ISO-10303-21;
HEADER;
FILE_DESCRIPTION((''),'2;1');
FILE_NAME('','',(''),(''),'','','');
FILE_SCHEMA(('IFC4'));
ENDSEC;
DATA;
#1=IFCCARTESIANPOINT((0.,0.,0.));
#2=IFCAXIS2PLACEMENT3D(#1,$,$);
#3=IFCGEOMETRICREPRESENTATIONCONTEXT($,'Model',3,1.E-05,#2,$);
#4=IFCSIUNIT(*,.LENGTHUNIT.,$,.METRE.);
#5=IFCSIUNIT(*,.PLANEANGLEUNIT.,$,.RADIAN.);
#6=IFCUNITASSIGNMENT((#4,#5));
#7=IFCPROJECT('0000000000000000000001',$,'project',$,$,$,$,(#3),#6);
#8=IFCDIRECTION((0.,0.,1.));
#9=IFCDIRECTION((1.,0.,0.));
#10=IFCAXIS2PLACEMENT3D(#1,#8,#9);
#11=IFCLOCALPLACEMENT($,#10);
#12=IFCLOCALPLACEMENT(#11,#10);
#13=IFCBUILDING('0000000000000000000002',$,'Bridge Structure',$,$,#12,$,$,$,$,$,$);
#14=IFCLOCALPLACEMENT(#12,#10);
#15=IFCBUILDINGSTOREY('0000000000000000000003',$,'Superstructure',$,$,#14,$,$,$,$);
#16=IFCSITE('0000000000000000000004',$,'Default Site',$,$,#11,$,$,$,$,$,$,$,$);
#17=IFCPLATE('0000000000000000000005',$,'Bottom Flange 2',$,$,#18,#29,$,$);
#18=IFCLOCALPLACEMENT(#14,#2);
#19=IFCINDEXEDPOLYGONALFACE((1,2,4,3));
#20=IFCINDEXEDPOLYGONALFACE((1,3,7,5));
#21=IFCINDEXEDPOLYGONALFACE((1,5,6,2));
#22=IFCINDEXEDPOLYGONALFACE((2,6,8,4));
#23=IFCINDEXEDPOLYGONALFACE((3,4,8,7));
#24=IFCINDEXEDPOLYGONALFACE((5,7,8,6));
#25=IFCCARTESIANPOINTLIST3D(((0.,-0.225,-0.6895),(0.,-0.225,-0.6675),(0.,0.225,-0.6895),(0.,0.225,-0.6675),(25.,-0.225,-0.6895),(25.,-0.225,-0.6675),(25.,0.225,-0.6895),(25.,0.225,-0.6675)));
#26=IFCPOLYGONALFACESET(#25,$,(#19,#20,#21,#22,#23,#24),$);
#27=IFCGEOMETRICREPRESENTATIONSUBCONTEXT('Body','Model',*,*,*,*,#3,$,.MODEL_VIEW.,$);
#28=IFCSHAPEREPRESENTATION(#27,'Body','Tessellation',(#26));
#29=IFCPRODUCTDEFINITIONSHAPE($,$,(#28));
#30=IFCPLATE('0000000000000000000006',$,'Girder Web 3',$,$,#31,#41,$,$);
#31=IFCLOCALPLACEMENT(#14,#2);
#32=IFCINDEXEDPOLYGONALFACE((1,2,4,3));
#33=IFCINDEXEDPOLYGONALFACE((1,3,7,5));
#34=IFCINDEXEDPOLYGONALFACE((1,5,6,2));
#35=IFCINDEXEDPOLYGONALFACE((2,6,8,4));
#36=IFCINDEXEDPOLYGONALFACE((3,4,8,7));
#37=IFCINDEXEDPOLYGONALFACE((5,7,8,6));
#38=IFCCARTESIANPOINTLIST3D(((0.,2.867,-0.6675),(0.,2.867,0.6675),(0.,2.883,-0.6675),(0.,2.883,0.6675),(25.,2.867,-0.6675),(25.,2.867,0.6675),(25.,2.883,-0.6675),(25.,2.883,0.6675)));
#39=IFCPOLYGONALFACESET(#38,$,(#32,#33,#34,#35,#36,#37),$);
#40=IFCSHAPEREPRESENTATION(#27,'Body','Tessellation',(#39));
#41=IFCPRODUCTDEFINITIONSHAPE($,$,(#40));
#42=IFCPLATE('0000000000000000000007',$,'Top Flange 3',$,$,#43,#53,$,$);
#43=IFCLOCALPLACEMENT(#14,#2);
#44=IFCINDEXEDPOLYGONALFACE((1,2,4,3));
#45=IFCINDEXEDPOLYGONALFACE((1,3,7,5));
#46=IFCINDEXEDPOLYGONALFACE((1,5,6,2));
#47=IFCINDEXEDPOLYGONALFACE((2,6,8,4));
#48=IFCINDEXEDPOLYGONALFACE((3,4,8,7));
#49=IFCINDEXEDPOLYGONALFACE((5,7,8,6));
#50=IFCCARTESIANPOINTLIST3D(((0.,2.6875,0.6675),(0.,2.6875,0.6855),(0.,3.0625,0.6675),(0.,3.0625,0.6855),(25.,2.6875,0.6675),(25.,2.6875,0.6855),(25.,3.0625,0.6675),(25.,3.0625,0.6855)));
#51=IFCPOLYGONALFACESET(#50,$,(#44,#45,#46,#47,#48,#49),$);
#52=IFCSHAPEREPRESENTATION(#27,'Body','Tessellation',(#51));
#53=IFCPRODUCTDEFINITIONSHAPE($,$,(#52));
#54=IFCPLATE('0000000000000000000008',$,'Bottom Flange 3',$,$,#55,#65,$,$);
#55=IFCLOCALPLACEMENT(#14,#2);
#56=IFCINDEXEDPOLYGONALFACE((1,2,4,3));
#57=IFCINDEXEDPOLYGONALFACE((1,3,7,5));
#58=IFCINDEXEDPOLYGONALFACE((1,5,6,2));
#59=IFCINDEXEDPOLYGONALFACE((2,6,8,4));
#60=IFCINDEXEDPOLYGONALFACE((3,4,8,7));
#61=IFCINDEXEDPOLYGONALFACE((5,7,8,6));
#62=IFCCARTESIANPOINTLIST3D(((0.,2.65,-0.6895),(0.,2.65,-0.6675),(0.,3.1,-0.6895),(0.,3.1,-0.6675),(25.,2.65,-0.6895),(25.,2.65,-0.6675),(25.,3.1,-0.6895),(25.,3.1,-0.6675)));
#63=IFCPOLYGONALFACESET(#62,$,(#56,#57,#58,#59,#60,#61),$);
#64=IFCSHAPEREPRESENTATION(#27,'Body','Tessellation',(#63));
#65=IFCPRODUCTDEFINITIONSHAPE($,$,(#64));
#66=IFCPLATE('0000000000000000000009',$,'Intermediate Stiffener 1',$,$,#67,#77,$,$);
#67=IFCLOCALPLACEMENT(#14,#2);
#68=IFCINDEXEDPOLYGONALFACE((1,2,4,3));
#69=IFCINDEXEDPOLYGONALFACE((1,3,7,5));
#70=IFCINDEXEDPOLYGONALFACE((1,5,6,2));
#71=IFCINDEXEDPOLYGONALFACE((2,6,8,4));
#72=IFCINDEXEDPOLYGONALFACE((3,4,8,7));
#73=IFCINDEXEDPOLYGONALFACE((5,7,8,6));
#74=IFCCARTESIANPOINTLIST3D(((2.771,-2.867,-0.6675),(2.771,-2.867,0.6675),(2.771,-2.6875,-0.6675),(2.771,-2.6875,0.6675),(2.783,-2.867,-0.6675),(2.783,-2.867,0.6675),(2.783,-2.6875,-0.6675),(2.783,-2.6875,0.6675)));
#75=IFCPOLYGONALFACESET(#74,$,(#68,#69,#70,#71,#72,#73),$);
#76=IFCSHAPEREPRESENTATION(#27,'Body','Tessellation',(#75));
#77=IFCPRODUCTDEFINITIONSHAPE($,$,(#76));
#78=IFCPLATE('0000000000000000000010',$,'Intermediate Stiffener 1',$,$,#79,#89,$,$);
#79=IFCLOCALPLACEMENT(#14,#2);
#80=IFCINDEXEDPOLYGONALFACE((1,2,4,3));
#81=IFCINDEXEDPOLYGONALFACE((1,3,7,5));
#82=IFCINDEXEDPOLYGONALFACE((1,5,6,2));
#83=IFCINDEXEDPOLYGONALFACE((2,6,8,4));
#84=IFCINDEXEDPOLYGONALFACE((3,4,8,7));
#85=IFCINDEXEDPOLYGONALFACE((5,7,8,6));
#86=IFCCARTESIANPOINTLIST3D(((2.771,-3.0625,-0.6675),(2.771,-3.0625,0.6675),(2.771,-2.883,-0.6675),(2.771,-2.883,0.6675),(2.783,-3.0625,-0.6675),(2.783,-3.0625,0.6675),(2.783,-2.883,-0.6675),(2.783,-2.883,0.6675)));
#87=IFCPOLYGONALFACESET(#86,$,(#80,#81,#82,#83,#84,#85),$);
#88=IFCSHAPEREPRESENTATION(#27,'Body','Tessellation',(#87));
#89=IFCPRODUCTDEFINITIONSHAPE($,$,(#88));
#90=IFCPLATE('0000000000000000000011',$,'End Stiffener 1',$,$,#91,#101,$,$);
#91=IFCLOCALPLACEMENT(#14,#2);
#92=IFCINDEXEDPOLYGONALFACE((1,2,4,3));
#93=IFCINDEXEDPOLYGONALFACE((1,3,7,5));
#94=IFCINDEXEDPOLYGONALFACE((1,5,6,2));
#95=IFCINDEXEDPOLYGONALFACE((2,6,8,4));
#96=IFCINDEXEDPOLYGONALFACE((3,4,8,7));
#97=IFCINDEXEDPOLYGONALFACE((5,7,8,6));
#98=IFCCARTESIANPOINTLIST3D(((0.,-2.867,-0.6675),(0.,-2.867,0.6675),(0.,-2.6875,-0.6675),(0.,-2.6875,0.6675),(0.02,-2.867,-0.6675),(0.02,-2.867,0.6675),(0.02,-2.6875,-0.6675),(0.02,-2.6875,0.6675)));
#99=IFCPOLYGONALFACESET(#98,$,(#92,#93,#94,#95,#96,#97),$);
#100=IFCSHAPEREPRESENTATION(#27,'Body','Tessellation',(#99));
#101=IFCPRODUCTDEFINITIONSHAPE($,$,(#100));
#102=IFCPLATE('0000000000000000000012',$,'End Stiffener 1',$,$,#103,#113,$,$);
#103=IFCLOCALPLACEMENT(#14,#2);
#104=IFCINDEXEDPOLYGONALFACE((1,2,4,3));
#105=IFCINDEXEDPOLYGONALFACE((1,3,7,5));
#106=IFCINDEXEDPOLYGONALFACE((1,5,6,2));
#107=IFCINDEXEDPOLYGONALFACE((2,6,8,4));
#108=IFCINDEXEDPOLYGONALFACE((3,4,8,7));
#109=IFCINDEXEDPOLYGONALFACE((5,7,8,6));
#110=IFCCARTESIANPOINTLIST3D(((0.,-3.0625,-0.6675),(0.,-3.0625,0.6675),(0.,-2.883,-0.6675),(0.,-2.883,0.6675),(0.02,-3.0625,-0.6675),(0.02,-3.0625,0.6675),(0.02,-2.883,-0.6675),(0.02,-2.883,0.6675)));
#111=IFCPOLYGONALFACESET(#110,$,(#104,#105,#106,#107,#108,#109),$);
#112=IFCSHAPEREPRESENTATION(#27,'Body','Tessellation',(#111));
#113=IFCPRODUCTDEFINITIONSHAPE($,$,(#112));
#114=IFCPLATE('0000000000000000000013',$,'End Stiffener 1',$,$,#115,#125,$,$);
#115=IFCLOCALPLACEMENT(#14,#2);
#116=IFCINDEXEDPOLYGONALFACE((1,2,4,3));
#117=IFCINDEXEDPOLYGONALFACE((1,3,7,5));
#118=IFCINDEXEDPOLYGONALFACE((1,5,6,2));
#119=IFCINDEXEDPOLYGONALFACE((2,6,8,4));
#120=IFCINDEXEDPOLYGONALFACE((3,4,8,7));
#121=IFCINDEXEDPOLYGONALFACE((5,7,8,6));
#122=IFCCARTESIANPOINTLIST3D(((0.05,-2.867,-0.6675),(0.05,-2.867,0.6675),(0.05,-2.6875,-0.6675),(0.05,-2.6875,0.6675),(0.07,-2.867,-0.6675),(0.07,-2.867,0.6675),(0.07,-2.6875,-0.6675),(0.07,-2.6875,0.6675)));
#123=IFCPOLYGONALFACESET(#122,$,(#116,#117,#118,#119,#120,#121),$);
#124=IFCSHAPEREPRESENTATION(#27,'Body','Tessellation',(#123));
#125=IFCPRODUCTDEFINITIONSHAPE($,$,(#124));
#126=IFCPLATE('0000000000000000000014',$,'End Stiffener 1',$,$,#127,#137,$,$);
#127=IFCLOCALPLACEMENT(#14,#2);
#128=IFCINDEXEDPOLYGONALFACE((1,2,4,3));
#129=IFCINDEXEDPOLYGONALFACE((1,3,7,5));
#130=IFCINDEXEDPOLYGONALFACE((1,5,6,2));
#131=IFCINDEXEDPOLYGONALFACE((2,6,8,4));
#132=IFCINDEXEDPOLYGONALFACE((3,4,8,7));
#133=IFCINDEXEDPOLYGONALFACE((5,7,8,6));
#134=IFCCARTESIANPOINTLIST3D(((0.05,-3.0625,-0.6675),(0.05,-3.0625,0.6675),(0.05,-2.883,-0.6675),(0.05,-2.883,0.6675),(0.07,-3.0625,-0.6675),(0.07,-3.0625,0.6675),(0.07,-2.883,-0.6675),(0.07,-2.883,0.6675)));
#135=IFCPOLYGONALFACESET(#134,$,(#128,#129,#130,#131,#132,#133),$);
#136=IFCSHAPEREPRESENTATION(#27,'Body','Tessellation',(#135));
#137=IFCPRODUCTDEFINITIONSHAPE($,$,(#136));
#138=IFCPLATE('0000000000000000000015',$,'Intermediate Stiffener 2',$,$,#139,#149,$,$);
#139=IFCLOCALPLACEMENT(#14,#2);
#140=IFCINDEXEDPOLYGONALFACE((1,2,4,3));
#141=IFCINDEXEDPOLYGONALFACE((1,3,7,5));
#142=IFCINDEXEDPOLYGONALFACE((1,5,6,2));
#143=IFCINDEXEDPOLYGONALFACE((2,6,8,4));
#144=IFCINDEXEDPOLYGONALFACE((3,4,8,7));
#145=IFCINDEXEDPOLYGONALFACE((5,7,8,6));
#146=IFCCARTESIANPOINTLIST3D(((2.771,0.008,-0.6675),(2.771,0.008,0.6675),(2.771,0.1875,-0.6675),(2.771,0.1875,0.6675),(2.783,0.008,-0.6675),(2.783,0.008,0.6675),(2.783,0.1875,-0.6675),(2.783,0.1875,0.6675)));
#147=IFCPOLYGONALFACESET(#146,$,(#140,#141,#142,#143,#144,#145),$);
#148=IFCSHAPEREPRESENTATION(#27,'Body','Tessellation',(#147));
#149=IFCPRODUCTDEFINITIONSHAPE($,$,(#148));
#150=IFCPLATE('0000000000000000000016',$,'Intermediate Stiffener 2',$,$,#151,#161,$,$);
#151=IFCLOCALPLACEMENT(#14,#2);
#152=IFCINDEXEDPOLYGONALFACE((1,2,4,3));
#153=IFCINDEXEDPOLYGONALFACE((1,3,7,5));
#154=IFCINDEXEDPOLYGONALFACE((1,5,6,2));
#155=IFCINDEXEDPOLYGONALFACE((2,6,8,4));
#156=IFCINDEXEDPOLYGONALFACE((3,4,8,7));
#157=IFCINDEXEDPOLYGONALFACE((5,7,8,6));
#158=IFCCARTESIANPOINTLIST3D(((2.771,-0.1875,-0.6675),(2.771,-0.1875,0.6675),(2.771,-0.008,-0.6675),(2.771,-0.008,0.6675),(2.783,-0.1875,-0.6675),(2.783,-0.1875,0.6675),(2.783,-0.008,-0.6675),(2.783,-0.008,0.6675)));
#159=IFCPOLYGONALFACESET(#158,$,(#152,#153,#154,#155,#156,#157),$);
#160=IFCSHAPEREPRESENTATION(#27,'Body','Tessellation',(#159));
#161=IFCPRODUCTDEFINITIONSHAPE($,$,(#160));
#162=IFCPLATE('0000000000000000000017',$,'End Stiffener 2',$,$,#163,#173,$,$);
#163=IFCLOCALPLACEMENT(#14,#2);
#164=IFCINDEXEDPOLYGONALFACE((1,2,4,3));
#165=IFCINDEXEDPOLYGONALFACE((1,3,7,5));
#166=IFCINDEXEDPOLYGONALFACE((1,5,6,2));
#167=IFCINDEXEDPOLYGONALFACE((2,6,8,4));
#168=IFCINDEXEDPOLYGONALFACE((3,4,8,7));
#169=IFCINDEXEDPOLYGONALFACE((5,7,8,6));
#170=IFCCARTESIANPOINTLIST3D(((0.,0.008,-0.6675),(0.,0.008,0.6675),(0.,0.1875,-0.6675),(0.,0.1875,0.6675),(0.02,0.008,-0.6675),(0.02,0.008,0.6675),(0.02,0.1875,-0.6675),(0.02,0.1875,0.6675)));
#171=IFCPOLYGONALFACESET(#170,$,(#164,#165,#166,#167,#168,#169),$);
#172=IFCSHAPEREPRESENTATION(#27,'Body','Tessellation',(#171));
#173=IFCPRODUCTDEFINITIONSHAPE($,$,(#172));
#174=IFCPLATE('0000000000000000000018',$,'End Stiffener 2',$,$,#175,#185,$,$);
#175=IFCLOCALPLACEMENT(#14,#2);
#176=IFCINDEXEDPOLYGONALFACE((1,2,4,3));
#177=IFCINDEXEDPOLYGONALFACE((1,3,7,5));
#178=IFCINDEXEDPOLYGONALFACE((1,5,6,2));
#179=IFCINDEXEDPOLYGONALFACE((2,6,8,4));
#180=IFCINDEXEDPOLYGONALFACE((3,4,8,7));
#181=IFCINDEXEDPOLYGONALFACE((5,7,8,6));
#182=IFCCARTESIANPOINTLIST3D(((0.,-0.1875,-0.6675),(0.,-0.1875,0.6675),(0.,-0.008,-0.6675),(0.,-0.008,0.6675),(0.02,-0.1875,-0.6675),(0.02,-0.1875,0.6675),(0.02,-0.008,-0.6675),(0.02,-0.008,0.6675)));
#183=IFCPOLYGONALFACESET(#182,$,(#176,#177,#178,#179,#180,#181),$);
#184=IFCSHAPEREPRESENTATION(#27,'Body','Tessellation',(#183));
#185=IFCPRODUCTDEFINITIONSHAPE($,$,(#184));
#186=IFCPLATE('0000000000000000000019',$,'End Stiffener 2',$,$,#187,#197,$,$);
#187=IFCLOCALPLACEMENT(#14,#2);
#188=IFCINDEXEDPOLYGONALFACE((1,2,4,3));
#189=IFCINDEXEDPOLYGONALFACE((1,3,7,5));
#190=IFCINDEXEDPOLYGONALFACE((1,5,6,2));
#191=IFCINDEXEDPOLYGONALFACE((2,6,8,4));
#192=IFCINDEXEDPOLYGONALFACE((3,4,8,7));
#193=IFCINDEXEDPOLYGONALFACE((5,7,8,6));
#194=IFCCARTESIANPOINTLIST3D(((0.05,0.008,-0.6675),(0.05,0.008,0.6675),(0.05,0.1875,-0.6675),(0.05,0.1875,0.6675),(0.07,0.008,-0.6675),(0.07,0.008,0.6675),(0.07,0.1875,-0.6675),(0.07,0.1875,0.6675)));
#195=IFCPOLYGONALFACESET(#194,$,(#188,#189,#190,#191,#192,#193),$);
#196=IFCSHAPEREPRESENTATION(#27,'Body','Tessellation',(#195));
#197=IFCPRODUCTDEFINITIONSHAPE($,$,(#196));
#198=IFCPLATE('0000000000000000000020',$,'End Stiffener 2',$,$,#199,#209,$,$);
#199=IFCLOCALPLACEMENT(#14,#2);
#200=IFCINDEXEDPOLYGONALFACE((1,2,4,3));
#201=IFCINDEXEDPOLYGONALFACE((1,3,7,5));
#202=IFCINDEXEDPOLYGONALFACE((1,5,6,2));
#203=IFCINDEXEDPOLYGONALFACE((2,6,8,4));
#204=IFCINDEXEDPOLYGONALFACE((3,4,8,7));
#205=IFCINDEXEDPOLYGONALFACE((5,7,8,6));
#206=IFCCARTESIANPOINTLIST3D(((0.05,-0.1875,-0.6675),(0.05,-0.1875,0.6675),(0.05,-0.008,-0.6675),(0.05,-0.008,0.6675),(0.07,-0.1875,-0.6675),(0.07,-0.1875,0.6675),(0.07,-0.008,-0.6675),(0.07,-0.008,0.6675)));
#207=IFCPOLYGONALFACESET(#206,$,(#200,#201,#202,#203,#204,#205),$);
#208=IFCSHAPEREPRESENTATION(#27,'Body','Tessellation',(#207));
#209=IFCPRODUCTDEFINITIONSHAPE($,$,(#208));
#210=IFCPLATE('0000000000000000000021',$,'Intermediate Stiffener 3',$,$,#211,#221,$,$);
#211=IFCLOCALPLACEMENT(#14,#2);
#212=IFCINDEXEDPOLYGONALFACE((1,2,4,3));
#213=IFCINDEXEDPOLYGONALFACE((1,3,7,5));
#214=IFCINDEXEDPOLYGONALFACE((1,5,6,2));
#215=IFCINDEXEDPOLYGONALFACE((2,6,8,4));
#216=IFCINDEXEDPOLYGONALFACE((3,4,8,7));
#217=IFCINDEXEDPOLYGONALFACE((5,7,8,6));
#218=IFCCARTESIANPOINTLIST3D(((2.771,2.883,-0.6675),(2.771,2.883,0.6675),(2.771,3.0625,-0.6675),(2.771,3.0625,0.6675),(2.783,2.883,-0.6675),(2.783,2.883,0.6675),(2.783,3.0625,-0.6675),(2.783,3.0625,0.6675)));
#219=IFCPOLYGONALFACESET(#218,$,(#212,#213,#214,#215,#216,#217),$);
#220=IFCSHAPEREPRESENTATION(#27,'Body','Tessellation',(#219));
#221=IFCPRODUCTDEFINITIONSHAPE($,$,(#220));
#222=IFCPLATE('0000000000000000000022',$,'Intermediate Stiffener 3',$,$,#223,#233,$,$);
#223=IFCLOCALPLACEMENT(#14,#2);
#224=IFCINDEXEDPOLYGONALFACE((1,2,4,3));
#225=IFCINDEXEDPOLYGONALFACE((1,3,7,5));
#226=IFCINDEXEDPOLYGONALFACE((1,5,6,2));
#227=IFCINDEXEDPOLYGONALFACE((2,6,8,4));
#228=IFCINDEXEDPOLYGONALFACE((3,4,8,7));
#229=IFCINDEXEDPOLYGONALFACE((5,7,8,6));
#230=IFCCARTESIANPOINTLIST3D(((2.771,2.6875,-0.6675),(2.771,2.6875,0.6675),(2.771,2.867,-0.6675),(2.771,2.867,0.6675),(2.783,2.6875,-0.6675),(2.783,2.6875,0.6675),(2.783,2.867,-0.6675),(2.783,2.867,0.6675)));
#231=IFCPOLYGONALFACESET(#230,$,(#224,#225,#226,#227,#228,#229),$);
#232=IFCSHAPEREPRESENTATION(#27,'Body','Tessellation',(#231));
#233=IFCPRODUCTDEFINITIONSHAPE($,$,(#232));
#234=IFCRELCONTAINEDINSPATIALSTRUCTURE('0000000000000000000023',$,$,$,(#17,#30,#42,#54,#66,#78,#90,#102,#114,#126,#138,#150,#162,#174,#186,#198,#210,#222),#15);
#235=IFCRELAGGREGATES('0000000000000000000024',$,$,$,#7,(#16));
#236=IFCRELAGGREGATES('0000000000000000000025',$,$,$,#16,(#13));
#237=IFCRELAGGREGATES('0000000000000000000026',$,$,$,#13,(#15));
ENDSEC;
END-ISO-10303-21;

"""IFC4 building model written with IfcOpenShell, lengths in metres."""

from ifc_helpers import new_model, si_unit, frame, origin, origin_with_axes, origin_2d_with_axis, place, context, subcontext, project, spatial, rectangle, extrude, element, save


model = new_model("IFC4")

# Units and contexts
model_context = context("Model", 3, precision=1e-05, world=origin())
body_context = subcontext(model_context, "Body", "Model", "MODEL_VIEW")
ifc_project = project(units=[si_unit("LENGTHUNIT", "METRE"), si_unit("PLANEANGLEUNIT", "RADIAN")], contexts=[model_context])

# Site, building, storey
site_placement = place(None, origin_with_axes())
site = spatial("IfcSite", under=ifc_project, at=site_placement, Name="Default Site")
building_placement = place(site_placement, origin_with_axes())
building = spatial("IfcBuilding", under=site, at=building_placement, Name="Bridge Structure")
storey_placement = place(building_placement, origin_with_axes())
storey = spatial("IfcBuildingStorey", under=building, at=storey_placement, Name="Superstructure")

# Plates
plate_1_placement = place(storey_placement, frame((0.0, 0.0, -0.6785), z_axis=(1.0, 0.0, 0.0), x_axis=(0.0, 1.0, 0.0)))
element("IfcPlate", 1, at=plate_1_placement, inside=storey, Name="Bottom Flange 2", context=body_context, shape_type="SweptSolid", body=[
    extrude(rectangle(XDim=0.45, YDim=0.022, at=origin_2d_with_axis()), origin_with_axes(), (0.0, 0.0, 1.0), 25.0),
])
plate_2_placement = place(storey_placement, frame((0.0, 2.875, 0.0), z_axis=(1.0, 0.0, 0.0), x_axis=(0.0, 1.0, 0.0)))
element("IfcPlate", 2, at=plate_2_placement, inside=storey, Name="Girder Web 3", context=body_context, shape_type="SweptSolid", body=[
    extrude(rectangle(XDim=0.016, YDim=1.335, at=origin_2d_with_axis()), origin_with_axes(), (0.0, 0.0, 1.0), 25.0),
])
plate_3_placement = place(storey_placement, frame((0.0, 2.875, 0.6765), z_axis=(1.0, 0.0, 0.0), x_axis=(0.0, 1.0, 0.0)))
element("IfcPlate", 3, at=plate_3_placement, inside=storey, Name="Top Flange 3", context=body_context, shape_type="SweptSolid", body=[
    extrude(rectangle(XDim=0.375, YDim=0.018, at=origin_2d_with_axis()), origin_with_axes(), (0.0, 0.0, 1.0), 25.0),
])
plate_4_placement = place(storey_placement, frame((0.0, 2.875, -0.6785), z_axis=(1.0, 0.0, 0.0), x_axis=(0.0, 1.0, 0.0)))
element("IfcPlate", 4, at=plate_4_placement, inside=storey, Name="Bottom Flange 3", context=body_context, shape_type="SweptSolid", body=[
    extrude(rectangle(XDim=0.45, YDim=0.022, at=origin_2d_with_axis()), origin_with_axes(), (0.0, 0.0, 1.0), 25.0),
])
for number, where, z_axis, x_axis, name in (
    (5, (2.777, -2.7772, -0.6675), (0.0, 0.0, 1.0), (1.0, 0.0, 0.0), "Intermediate Stiffener 1"),
    (6, (2.777, -2.9728, -0.6675), (0.0, 0.0, 1.0), (1.0, 0.0, 0.0), "Intermediate Stiffener 1"),
):
    element("IfcPlate", number, at=place(storey_placement, frame(where, z_axis=z_axis, x_axis=x_axis)), inside=storey, Name=name, context=body_context, shape_type="SweptSolid", body=[
        extrude(rectangle(XDim=0.012, YDim=0.1795, at=origin_2d_with_axis()), origin_with_axes(), (0.0, 0.0, 1.0), 1.335),
    ])
for number, where, z_axis, x_axis, name in (
    (7, (0.01, -2.7772, -0.6675), (0.0, 0.0, 1.0), (1.0, 0.0, 0.0), "End Stiffener 1"),
    (8, (0.01, -2.9728, -0.6675), (0.0, 0.0, 1.0), (1.0, 0.0, 0.0), "End Stiffener 1"),
    (9, (0.06, -2.7772, -0.6675), (0.0, 0.0, 1.0), (1.0, 0.0, 0.0), "End Stiffener 1"),
    (10, (0.06, -2.9728, -0.6675), (0.0, 0.0, 1.0), (1.0, 0.0, 0.0), "End Stiffener 1"),
):
    element("IfcPlate", number, at=place(storey_placement, frame(where, z_axis=z_axis, x_axis=x_axis)), inside=storey, Name=name, context=body_context, shape_type="SweptSolid", body=[
        extrude(rectangle(XDim=0.02, YDim=0.1795, at=origin_2d_with_axis()), origin_with_axes(), (0.0, 0.0, 1.0), 1.335),
    ])
for number, where, z_axis, x_axis, name in (
    (11, (2.777, 0.0978, -0.6675), (0.0, 0.0, 1.0), (1.0, 0.0, 0.0), "Intermediate Stiffener 2"),
    (12, (2.777, -0.0978, -0.6675), (0.0, 0.0, 1.0), (1.0, 0.0, 0.0), "Intermediate Stiffener 2"),
):
    element("IfcPlate", number, at=place(storey_placement, frame(where, z_axis=z_axis, x_axis=x_axis)), inside=storey, Name=name, context=body_context, shape_type="SweptSolid", body=[
        extrude(rectangle(XDim=0.012, YDim=0.1795, at=origin_2d_with_axis()), origin_with_axes(), (0.0, 0.0, 1.0), 1.335),
    ])
for number, where, z_axis, x_axis, name in (
    (13, (0.01, 0.0978, -0.6675), (0.0, 0.0, 1.0), (1.0, 0.0, 0.0), "End Stiffener 2"),
    (14, (0.01, -0.0978, -0.6675), (0.0, 0.0, 1.0), (1.0, 0.0, 0.0), "End Stiffener 2"),
    (15, (0.06, 0.0978, -0.6675), (0.0, 0.0, 1.0), (1.0, 0.0, 0.0), "End Stiffener 2"),
    (16, (0.06, -0.0978, -0.6675), (0.0, 0.0, 1.0), (1.0, 0.0, 0.0), "End Stiffener 2"),
):
    element("IfcPlate", number, at=place(storey_placement, frame(where, z_axis=z_axis, x_axis=x_axis)), inside=storey, Name=name, context=body_context, shape_type="SweptSolid", body=[
        extrude(rectangle(XDim=0.02, YDim=0.1795, at=origin_2d_with_axis()), origin_with_axes(), (0.0, 0.0, 1.0), 1.335),
    ])
for number, where, z_axis, x_axis, name in (
    (17, (2.777, 2.9728, -0.6675), (0.0, 0.0, 1.0), (1.0, 0.0, 0.0), "Intermediate Stiffener 3"),
    (18, (2.777, 2.7772, -0.6675), (0.0, 0.0, 1.0), (1.0, 0.0, 0.0), "Intermediate Stiffener 3"),
):
    element("IfcPlate", number, at=place(storey_placement, frame(where, z_axis=z_axis, x_axis=x_axis)), inside=storey, Name=name, context=body_context, shape_type="SweptSolid", body=[
        extrude(rectangle(XDim=0.012, YDim=0.1795, at=origin_2d_with_axis()), origin_with_axes(), (0.0, 0.0, 1.0), 1.335),
    ])

save(model, "model.ifc")
